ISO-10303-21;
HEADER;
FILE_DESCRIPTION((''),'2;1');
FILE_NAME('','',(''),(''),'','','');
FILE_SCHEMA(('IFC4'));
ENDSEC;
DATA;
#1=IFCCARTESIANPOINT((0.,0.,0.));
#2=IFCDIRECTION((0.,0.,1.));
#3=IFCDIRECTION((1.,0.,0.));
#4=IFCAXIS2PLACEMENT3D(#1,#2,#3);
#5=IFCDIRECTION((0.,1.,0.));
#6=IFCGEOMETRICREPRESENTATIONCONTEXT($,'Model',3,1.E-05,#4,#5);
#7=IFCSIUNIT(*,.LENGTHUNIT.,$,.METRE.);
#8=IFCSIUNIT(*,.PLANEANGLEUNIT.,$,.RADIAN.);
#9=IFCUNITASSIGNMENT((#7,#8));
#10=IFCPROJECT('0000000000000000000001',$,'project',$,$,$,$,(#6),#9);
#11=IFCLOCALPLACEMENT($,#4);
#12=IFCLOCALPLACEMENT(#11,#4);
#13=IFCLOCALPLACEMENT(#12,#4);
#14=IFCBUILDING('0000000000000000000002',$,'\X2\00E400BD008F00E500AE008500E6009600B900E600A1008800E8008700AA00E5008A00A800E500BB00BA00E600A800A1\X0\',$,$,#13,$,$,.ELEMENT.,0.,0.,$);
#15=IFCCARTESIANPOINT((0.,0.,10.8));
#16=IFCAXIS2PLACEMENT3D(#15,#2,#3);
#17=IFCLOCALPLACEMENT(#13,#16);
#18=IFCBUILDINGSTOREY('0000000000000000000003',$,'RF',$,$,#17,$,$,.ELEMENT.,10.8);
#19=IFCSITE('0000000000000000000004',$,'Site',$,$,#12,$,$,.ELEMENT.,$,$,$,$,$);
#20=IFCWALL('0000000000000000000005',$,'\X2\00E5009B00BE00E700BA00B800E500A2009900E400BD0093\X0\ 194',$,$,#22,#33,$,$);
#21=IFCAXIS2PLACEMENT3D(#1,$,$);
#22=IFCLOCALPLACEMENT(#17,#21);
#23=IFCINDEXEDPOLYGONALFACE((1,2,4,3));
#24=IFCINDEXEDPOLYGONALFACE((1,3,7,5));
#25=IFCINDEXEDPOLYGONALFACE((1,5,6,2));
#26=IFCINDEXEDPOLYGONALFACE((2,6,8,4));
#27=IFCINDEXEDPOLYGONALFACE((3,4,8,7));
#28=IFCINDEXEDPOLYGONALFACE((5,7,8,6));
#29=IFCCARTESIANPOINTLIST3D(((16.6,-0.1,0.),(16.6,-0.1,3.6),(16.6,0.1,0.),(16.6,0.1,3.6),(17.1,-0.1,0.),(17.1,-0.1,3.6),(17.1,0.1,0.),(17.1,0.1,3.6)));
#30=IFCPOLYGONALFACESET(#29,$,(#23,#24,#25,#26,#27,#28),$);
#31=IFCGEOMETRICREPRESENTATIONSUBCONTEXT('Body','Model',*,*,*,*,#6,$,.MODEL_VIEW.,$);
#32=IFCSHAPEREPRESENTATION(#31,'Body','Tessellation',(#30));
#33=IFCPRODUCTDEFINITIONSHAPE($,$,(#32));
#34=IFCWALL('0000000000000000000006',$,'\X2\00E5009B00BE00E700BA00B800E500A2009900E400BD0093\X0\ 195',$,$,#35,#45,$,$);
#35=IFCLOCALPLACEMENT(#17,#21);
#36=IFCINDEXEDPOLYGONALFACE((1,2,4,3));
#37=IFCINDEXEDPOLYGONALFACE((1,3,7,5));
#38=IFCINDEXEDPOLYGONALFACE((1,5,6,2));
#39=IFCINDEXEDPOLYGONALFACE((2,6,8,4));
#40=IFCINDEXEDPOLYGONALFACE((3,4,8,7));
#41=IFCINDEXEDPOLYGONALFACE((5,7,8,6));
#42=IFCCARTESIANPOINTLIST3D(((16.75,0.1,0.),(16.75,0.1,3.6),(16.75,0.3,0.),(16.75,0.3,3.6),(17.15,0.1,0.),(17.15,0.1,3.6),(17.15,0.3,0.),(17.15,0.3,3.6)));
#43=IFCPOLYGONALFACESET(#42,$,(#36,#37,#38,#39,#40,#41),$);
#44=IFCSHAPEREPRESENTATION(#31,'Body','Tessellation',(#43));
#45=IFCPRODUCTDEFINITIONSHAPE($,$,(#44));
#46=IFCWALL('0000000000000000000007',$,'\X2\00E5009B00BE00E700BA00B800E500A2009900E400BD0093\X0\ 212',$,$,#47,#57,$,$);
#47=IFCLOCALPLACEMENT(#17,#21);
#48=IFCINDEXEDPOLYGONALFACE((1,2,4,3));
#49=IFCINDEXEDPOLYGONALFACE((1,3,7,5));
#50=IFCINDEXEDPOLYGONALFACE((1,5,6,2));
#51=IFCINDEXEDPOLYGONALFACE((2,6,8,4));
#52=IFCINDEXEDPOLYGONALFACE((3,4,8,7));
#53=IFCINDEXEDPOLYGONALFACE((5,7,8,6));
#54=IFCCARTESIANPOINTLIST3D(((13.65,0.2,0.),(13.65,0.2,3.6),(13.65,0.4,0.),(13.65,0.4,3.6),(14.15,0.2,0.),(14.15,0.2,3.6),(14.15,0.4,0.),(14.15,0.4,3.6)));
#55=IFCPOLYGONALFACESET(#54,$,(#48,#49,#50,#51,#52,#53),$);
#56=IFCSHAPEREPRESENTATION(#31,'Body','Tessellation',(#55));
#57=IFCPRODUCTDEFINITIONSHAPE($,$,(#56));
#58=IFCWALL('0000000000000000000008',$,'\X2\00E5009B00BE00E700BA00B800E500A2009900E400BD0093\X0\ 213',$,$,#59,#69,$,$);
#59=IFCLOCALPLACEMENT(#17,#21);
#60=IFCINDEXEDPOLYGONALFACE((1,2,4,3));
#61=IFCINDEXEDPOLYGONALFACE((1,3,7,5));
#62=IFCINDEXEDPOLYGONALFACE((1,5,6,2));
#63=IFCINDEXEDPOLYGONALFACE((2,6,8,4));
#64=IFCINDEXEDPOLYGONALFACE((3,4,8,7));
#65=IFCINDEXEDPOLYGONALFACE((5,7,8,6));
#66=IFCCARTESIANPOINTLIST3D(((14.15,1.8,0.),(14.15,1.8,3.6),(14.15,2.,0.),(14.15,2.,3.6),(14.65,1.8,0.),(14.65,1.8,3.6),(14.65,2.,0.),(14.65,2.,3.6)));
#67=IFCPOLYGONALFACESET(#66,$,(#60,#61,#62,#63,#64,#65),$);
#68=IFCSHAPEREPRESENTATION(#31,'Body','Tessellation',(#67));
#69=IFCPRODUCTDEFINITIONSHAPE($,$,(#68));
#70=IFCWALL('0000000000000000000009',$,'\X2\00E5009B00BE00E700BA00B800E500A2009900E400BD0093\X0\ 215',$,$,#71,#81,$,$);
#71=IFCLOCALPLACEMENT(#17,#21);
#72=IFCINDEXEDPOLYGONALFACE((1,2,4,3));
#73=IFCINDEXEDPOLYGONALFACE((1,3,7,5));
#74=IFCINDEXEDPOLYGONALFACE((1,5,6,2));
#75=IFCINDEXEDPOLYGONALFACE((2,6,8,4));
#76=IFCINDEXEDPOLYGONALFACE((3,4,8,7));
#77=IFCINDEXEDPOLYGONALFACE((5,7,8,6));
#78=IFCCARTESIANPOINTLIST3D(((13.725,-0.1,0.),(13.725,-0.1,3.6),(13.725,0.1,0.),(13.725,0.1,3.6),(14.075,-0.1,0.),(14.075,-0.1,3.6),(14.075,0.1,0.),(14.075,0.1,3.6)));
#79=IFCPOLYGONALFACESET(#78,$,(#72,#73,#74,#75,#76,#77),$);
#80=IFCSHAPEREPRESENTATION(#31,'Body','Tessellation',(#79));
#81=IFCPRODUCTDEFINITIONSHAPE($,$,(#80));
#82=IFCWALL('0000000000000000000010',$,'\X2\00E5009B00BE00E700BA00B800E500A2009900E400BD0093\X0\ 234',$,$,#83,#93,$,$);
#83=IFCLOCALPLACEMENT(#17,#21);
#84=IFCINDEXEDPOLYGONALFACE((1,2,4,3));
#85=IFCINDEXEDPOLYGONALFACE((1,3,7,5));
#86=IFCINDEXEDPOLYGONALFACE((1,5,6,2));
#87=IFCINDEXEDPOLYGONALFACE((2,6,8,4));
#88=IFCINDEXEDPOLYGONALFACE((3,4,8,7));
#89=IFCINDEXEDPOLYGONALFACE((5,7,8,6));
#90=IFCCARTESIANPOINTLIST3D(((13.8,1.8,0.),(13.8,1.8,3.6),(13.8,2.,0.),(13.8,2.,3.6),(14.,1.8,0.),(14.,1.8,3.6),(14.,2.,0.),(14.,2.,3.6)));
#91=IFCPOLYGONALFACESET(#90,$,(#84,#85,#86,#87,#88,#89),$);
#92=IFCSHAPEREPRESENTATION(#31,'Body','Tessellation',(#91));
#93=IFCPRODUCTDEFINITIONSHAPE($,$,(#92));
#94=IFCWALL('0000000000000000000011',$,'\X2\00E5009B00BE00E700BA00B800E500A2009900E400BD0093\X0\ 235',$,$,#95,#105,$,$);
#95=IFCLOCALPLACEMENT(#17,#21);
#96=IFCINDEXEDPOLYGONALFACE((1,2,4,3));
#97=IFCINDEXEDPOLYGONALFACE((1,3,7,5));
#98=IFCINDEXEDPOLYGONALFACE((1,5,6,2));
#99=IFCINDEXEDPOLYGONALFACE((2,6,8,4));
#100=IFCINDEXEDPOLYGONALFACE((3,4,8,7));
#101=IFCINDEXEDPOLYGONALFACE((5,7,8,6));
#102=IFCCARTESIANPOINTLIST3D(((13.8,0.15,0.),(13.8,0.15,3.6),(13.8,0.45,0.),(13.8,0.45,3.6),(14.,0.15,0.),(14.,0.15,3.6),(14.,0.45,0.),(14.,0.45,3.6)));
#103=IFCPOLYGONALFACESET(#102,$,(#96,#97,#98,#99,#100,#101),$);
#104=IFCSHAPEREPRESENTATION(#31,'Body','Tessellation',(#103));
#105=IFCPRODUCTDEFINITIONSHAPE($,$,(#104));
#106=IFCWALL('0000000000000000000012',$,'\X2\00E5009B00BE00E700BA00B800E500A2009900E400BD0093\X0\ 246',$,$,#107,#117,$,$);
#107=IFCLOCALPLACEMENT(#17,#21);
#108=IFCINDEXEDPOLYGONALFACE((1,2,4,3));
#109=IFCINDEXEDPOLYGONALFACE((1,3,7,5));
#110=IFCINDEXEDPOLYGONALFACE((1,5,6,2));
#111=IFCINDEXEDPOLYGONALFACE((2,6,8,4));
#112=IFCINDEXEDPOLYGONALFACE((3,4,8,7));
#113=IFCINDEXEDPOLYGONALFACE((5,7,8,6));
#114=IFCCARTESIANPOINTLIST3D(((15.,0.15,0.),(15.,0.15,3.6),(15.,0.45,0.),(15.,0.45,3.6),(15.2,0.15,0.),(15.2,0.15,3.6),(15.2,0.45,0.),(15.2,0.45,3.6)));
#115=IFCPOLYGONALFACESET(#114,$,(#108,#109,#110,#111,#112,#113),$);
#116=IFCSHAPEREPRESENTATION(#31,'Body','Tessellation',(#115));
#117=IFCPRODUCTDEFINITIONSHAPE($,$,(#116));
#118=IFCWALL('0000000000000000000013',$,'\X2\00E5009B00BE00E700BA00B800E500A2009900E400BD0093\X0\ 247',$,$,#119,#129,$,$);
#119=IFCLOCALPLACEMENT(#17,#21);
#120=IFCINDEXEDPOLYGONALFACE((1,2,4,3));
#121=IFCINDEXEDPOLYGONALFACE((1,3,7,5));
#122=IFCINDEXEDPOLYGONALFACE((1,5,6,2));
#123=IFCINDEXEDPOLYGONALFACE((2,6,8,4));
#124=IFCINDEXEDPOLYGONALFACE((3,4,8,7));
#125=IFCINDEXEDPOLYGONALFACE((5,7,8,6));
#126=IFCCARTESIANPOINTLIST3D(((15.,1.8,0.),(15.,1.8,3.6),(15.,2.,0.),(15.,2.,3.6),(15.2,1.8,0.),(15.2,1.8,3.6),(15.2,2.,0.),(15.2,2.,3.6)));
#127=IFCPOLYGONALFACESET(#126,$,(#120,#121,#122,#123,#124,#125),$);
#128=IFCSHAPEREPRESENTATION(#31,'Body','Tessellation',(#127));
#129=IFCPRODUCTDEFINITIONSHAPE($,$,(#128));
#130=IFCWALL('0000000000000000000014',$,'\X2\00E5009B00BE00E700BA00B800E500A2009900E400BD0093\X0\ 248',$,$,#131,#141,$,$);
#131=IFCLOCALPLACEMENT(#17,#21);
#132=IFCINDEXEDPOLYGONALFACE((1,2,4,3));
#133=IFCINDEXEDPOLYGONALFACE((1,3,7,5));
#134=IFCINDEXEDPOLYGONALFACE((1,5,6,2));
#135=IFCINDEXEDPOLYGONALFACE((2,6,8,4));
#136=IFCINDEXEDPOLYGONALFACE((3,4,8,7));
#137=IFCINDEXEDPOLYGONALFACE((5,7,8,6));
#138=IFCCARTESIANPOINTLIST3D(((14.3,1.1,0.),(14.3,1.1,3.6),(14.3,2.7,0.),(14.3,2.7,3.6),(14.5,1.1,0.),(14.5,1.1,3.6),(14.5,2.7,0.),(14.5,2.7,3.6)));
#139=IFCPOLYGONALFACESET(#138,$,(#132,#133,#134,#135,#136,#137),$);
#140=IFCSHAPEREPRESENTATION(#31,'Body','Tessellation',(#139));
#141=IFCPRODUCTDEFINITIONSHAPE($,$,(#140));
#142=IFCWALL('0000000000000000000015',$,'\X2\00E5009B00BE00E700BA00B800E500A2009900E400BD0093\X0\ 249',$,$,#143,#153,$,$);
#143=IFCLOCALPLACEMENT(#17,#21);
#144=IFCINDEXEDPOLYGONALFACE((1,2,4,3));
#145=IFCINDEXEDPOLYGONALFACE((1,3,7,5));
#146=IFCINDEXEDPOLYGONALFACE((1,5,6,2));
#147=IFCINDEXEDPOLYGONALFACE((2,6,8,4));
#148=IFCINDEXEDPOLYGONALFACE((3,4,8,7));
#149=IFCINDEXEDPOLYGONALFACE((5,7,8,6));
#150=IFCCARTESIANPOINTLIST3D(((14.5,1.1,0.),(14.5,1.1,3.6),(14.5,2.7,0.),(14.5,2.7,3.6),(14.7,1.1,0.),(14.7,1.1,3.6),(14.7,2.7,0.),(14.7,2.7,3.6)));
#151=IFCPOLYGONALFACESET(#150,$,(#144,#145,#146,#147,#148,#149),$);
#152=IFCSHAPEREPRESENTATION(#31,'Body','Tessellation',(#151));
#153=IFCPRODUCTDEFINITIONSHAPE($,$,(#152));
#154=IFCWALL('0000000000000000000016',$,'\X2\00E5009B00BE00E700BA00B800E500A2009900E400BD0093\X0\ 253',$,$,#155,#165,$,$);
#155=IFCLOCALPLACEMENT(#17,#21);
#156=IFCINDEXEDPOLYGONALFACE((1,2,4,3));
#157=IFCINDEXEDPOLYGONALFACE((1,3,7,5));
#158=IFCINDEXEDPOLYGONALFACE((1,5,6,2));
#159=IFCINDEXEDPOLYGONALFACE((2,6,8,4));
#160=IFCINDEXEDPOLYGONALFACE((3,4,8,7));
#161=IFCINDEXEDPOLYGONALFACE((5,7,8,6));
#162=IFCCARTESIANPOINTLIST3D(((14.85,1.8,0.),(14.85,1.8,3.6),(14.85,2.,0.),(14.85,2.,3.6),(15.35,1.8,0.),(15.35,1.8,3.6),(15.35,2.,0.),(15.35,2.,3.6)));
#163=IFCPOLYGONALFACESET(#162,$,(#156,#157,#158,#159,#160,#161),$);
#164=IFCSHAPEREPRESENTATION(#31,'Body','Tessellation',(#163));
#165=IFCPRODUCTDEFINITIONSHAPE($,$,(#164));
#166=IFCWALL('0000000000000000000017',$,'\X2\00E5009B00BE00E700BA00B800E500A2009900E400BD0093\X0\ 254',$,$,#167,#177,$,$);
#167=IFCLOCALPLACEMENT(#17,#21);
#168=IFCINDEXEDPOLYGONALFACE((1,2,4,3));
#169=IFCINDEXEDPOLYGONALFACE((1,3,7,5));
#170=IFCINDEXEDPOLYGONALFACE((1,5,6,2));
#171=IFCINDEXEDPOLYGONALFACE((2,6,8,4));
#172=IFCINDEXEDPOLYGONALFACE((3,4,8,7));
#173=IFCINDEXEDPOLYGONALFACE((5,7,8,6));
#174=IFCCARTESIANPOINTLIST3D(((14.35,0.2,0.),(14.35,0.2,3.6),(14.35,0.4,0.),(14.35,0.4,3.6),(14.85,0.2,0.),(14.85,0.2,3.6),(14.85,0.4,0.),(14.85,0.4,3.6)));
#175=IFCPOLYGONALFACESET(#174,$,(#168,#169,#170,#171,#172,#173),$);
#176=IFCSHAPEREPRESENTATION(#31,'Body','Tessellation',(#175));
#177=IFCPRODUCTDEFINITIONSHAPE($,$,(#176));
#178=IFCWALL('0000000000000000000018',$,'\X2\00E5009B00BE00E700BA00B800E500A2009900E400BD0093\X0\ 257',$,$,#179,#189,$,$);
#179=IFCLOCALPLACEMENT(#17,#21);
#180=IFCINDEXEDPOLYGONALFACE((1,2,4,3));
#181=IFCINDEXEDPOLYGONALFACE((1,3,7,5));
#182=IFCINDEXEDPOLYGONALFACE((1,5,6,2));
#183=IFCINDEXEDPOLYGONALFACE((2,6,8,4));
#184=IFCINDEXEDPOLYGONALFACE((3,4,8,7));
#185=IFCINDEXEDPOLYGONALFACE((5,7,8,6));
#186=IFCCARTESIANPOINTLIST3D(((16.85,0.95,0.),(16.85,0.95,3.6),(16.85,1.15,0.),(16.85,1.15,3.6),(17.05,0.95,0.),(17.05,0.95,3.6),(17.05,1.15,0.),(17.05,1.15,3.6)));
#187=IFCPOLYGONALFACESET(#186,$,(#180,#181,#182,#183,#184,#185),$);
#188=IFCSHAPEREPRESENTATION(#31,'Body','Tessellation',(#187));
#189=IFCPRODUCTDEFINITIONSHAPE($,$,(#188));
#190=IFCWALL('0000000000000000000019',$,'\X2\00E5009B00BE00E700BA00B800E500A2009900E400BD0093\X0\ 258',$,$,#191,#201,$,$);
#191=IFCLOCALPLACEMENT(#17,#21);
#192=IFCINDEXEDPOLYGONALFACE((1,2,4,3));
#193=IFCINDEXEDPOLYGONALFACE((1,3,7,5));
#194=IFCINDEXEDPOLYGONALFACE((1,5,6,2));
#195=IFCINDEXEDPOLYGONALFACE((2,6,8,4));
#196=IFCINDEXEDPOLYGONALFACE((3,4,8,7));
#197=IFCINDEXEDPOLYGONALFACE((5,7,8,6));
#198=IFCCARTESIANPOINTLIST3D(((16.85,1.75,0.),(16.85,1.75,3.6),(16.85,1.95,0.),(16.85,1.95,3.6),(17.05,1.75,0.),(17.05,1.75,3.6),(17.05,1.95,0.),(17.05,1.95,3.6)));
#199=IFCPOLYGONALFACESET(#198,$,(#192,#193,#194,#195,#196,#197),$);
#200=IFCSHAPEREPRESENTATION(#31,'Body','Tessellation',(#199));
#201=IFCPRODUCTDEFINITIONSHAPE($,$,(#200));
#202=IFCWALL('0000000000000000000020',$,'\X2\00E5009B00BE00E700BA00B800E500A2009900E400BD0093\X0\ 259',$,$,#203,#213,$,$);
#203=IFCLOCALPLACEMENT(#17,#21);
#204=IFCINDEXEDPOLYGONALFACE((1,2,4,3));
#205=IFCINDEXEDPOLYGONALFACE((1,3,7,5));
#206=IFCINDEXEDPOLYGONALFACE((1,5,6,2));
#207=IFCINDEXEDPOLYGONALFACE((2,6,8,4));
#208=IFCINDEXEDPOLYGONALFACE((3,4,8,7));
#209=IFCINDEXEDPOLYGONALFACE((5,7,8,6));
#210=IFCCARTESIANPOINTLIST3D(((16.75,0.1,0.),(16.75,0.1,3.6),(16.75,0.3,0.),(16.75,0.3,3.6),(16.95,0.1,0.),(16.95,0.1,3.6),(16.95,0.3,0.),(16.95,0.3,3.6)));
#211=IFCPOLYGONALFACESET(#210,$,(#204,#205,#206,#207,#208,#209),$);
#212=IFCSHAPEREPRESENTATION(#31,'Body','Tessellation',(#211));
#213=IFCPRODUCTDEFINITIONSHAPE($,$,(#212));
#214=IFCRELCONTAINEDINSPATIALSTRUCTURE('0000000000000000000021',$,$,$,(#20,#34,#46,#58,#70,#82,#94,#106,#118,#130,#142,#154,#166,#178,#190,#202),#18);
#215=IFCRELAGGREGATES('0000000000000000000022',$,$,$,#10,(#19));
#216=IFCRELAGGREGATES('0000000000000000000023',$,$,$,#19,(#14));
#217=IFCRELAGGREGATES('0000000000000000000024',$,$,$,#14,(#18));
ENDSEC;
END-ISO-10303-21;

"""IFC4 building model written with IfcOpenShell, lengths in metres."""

from ifc_helpers import new_model, si_unit, direction, frame, frame_2d, origin_with_axes, place, context, subcontext, project, spatial, rectangle, extrude, element, save


model = new_model("IFC4")

# Units and contexts
model_context = context("Model", 3, precision=1e-05, world=origin_with_axes(), true_north=direction((0.0, 1.0, 0.0)))
body_context = subcontext(model_context, "Body", "Model", "MODEL_VIEW")
ifc_project = project(units=[si_unit("LENGTHUNIT", "METRE"), si_unit("PLANEANGLEUNIT", "RADIAN")], contexts=[model_context])

# Site, building, storey
placement = place(None, origin_with_axes())
site_placement = place(placement, origin_with_axes())
site = spatial("IfcSite", under=ifc_project, at=site_placement, Name="Site", CompositionType="ELEMENT")
building_placement = place(site_placement, origin_with_axes())
building = spatial("IfcBuilding", under=site, at=building_placement, Name="ä½\u008få®\u0085æ\u0096¹æ¡\u0088è\u0087ªå\u008a¨å»ºæ¨¡", CompositionType="ELEMENT", ElevationOfRefHeight=0.0, ElevationOfTerrain=0.0)
storey_placement = place(building_placement, frame((0.0, 0.0, 10.8), z_axis=(0.0, 0.0, 1.0), x_axis=(1.0, 0.0, 0.0)))
storey = spatial("IfcBuildingStorey", under=building, at=storey_placement, Name="RF", CompositionType="ELEMENT", Elevation=10.8)

# Walls
wall_1_placement = place(storey_placement, frame((16.85, 0.0, 0.0), z_axis=(0.0, 0.0, 1.0), x_axis=(1.0, 0.0, 0.0)))
element("IfcWall", 1, at=wall_1_placement, inside=storey, Name="å\u009b¾çº¸å¢\u0099ä½\u0093 194", context=body_context, shape_type="SweptSolid", body=[
    extrude(rectangle(XDim=0.5, YDim=0.2, at=frame_2d((0.0, 0.0), x_axis=(1.0, 0.0, 0.0))), frame((0.0, 0.0, 0.0), z_axis=(0.0, 0.0, 1.0)), (0.0, 0.0, 1.0), 3.6),
])
wall_2_placement = place(storey_placement, frame((16.95, 0.2, 0.0), z_axis=(0.0, 0.0, 1.0), x_axis=(1.0, 0.0, 0.0)))
element("IfcWall", 2, at=wall_2_placement, inside=storey, Name="å\u009b¾çº¸å¢\u0099ä½\u0093 195", context=body_context, shape_type="SweptSolid", body=[
    extrude(rectangle(XDim=0.4, YDim=0.2, at=frame_2d((0.0, 0.0), x_axis=(1.0, 0.0, 0.0))), frame((0.0, 0.0, 0.0), z_axis=(0.0, 0.0, 1.0)), (0.0, 0.0, 1.0), 3.6),
])
for number, where, z_axis, x_axis, name in (
    (3, (13.9, 0.3, 0.0), (0.0, 0.0, 1.0), (1.0, 0.0, 0.0), "å\u009b¾çº¸å¢\u0099ä½\u0093 212"),
    (4, (14.4, 1.9, 0.0), (0.0, 0.0, 1.0), (-1.0, 0.0, 0.0), "å\u009b¾çº¸å¢\u0099ä½\u0093 213"),
):
    element("IfcWall", number, at=place(storey_placement, frame(where, z_axis=z_axis, x_axis=x_axis)), inside=storey, Name=name, context=body_context, shape_type="SweptSolid", body=[
        extrude(rectangle(XDim=0.5, YDim=0.2, at=frame_2d((0.0, 0.0), x_axis=(1.0, 0.0, 0.0))), frame((0.0, 0.0, 0.0), z_axis=(0.0, 0.0, 1.0)), (0.0, 0.0, 1.0), 3.6),
    ])
wall_3_placement = place(storey_placement, frame((13.9, 0.0, 0.0), z_axis=(0.0, 0.0, 1.0), x_axis=(1.0, 0.0, 0.0)))
element("IfcWall", 5, at=wall_3_placement, inside=storey, Name="å\u009b¾çº¸å¢\u0099ä½\u0093 215", context=body_context, shape_type="SweptSolid", body=[
    extrude(rectangle(XDim=0.35, YDim=0.2, at=frame_2d((0.0, 0.0), x_axis=(1.0, 0.0, 0.0))), frame((0.0, 0.0, 0.0), z_axis=(0.0, 0.0, 1.0)), (0.0, 0.0, 1.0), 3.6),
])
wall_4_placement = place(storey_placement, frame((13.9, 1.9, 0.0), z_axis=(0.0, 0.0, 1.0), x_axis=(0.0, 1.0, 0.0)))
element("IfcWall", 6, at=wall_4_placement, inside=storey, Name="å\u009b¾çº¸å¢\u0099ä½\u0093 234", context=body_context, shape_type="SweptSolid", body=[
    extrude(rectangle(XDim=0.2, YDim=0.2, at=frame_2d((0.0, 0.0), x_axis=(1.0, 0.0, 0.0))), frame((0.0, 0.0, 0.0), z_axis=(0.0, 0.0, 1.0)), (0.0, 0.0, 1.0), 3.6),
])
for number, where, z_axis, x_axis, name in (
    (7, (13.9, 0.3, 0.0), (0.0, 0.0, 1.0), (0.0, -1.0, 0.0), "å\u009b¾çº¸å¢\u0099ä½\u0093 235"),
    (8, (15.1, 0.3, 0.0), (0.0, 0.0, 1.0), (0.0, -1.0, 0.0), "å\u009b¾çº¸å¢\u0099ä½\u0093 246"),
):
    element("IfcWall", number, at=place(storey_placement, frame(where, z_axis=z_axis, x_axis=x_axis)), inside=storey, Name=name, context=body_context, shape_type="SweptSolid", body=[
        extrude(rectangle(XDim=0.3, YDim=0.2, at=frame_2d((0.0, 0.0), x_axis=(1.0, 0.0, 0.0))), frame((0.0, 0.0, 0.0), z_axis=(0.0, 0.0, 1.0)), (0.0, 0.0, 1.0), 3.6),
    ])
wall_5_placement = place(storey_placement, frame((15.1, 1.9, 0.0), z_axis=(0.0, 0.0, 1.0), x_axis=(0.0, 1.0, 0.0)))
element("IfcWall", 9, at=wall_5_placement, inside=storey, Name="å\u009b¾çº¸å¢\u0099ä½\u0093 247", context=body_context, shape_type="SweptSolid", body=[
    extrude(rectangle(XDim=0.2, YDim=0.2, at=frame_2d((0.0, 0.0), x_axis=(1.0, 0.0, 0.0))), frame((0.0, 0.0, 0.0), z_axis=(0.0, 0.0, 1.0)), (0.0, 0.0, 1.0), 3.6),
])
for number, where, z_axis, x_axis, name in (
    (10, (14.4, 1.9, 0.0), (0.0, 0.0, 1.0), (0.0, -1.0, 0.0), "å\u009b¾çº¸å¢\u0099ä½\u0093 248"),
    (11, (14.6, 1.9, 0.0), (0.0, 0.0, 1.0), (0.0, -1.0, 0.0), "å\u009b¾çº¸å¢\u0099ä½\u0093 249"),
):
    element("IfcWall", number, at=place(storey_placement, frame(where, z_axis=z_axis, x_axis=x_axis)), inside=storey, Name=name, context=body_context, shape_type="SweptSolid", body=[
        extrude(rectangle(XDim=1.6, YDim=0.2, at=frame_2d((0.0, 0.0), x_axis=(1.0, 0.0, 0.0))), frame((0.0, 0.0, 0.0), z_axis=(0.0, 0.0, 1.0)), (0.0, 0.0, 1.0), 3.6),
    ])
for number, where, z_axis, x_axis, name in (
    (12, (15.1, 1.9, 0.0), (0.0, 0.0, 1.0), (-1.0, 0.0, 0.0), "å\u009b¾çº¸å¢\u0099ä½\u0093 253"),
    (13, (14.6, 0.3, 0.0), (0.0, 0.0, 1.0), (1.0, 0.0, 0.0), "å\u009b¾çº¸å¢\u0099ä½\u0093 254"),
):
    element("IfcWall", number, at=place(storey_placement, frame(where, z_axis=z_axis, x_axis=x_axis)), inside=storey, Name=name, context=body_context, shape_type="SweptSolid", body=[
        extrude(rectangle(XDim=0.5, YDim=0.2, at=frame_2d((0.0, 0.0), x_axis=(1.0, 0.0, 0.0))), frame((0.0, 0.0, 0.0), z_axis=(0.0, 0.0, 1.0)), (0.0, 0.0, 1.0), 3.6),
    ])
for number, where, z_axis, x_axis, name in (
    (14, (16.95, 1.05, 0.0), (0.0, 0.0, 1.0), (-1.0, 0.0, 0.0), "å\u009b¾çº¸å¢\u0099ä½\u0093 257"),
    (15, (16.95, 1.85, 0.0), (0.0, 0.0, 1.0), (-1.0, 0.0, 0.0), "å\u009b¾çº¸å¢\u0099ä½\u0093 258"),
    (16, (16.85, 0.2, 0.0), (0.0, 0.0, 1.0), (0.0, -1.0, 0.0), "å\u009b¾çº¸å¢\u0099ä½\u0093 259"),
):
    element("IfcWall", number, at=place(storey_placement, frame(where, z_axis=z_axis, x_axis=x_axis)), inside=storey, Name=name, context=body_context, shape_type="SweptSolid", body=[
        extrude(rectangle(XDim=0.2, YDim=0.2, at=frame_2d((0.0, 0.0), x_axis=(1.0, 0.0, 0.0))), frame((0.0, 0.0, 0.0), z_axis=(0.0, 0.0, 1.0)), (0.0, 0.0, 1.0), 3.6),
    ])

save(model, "model.ifc")
